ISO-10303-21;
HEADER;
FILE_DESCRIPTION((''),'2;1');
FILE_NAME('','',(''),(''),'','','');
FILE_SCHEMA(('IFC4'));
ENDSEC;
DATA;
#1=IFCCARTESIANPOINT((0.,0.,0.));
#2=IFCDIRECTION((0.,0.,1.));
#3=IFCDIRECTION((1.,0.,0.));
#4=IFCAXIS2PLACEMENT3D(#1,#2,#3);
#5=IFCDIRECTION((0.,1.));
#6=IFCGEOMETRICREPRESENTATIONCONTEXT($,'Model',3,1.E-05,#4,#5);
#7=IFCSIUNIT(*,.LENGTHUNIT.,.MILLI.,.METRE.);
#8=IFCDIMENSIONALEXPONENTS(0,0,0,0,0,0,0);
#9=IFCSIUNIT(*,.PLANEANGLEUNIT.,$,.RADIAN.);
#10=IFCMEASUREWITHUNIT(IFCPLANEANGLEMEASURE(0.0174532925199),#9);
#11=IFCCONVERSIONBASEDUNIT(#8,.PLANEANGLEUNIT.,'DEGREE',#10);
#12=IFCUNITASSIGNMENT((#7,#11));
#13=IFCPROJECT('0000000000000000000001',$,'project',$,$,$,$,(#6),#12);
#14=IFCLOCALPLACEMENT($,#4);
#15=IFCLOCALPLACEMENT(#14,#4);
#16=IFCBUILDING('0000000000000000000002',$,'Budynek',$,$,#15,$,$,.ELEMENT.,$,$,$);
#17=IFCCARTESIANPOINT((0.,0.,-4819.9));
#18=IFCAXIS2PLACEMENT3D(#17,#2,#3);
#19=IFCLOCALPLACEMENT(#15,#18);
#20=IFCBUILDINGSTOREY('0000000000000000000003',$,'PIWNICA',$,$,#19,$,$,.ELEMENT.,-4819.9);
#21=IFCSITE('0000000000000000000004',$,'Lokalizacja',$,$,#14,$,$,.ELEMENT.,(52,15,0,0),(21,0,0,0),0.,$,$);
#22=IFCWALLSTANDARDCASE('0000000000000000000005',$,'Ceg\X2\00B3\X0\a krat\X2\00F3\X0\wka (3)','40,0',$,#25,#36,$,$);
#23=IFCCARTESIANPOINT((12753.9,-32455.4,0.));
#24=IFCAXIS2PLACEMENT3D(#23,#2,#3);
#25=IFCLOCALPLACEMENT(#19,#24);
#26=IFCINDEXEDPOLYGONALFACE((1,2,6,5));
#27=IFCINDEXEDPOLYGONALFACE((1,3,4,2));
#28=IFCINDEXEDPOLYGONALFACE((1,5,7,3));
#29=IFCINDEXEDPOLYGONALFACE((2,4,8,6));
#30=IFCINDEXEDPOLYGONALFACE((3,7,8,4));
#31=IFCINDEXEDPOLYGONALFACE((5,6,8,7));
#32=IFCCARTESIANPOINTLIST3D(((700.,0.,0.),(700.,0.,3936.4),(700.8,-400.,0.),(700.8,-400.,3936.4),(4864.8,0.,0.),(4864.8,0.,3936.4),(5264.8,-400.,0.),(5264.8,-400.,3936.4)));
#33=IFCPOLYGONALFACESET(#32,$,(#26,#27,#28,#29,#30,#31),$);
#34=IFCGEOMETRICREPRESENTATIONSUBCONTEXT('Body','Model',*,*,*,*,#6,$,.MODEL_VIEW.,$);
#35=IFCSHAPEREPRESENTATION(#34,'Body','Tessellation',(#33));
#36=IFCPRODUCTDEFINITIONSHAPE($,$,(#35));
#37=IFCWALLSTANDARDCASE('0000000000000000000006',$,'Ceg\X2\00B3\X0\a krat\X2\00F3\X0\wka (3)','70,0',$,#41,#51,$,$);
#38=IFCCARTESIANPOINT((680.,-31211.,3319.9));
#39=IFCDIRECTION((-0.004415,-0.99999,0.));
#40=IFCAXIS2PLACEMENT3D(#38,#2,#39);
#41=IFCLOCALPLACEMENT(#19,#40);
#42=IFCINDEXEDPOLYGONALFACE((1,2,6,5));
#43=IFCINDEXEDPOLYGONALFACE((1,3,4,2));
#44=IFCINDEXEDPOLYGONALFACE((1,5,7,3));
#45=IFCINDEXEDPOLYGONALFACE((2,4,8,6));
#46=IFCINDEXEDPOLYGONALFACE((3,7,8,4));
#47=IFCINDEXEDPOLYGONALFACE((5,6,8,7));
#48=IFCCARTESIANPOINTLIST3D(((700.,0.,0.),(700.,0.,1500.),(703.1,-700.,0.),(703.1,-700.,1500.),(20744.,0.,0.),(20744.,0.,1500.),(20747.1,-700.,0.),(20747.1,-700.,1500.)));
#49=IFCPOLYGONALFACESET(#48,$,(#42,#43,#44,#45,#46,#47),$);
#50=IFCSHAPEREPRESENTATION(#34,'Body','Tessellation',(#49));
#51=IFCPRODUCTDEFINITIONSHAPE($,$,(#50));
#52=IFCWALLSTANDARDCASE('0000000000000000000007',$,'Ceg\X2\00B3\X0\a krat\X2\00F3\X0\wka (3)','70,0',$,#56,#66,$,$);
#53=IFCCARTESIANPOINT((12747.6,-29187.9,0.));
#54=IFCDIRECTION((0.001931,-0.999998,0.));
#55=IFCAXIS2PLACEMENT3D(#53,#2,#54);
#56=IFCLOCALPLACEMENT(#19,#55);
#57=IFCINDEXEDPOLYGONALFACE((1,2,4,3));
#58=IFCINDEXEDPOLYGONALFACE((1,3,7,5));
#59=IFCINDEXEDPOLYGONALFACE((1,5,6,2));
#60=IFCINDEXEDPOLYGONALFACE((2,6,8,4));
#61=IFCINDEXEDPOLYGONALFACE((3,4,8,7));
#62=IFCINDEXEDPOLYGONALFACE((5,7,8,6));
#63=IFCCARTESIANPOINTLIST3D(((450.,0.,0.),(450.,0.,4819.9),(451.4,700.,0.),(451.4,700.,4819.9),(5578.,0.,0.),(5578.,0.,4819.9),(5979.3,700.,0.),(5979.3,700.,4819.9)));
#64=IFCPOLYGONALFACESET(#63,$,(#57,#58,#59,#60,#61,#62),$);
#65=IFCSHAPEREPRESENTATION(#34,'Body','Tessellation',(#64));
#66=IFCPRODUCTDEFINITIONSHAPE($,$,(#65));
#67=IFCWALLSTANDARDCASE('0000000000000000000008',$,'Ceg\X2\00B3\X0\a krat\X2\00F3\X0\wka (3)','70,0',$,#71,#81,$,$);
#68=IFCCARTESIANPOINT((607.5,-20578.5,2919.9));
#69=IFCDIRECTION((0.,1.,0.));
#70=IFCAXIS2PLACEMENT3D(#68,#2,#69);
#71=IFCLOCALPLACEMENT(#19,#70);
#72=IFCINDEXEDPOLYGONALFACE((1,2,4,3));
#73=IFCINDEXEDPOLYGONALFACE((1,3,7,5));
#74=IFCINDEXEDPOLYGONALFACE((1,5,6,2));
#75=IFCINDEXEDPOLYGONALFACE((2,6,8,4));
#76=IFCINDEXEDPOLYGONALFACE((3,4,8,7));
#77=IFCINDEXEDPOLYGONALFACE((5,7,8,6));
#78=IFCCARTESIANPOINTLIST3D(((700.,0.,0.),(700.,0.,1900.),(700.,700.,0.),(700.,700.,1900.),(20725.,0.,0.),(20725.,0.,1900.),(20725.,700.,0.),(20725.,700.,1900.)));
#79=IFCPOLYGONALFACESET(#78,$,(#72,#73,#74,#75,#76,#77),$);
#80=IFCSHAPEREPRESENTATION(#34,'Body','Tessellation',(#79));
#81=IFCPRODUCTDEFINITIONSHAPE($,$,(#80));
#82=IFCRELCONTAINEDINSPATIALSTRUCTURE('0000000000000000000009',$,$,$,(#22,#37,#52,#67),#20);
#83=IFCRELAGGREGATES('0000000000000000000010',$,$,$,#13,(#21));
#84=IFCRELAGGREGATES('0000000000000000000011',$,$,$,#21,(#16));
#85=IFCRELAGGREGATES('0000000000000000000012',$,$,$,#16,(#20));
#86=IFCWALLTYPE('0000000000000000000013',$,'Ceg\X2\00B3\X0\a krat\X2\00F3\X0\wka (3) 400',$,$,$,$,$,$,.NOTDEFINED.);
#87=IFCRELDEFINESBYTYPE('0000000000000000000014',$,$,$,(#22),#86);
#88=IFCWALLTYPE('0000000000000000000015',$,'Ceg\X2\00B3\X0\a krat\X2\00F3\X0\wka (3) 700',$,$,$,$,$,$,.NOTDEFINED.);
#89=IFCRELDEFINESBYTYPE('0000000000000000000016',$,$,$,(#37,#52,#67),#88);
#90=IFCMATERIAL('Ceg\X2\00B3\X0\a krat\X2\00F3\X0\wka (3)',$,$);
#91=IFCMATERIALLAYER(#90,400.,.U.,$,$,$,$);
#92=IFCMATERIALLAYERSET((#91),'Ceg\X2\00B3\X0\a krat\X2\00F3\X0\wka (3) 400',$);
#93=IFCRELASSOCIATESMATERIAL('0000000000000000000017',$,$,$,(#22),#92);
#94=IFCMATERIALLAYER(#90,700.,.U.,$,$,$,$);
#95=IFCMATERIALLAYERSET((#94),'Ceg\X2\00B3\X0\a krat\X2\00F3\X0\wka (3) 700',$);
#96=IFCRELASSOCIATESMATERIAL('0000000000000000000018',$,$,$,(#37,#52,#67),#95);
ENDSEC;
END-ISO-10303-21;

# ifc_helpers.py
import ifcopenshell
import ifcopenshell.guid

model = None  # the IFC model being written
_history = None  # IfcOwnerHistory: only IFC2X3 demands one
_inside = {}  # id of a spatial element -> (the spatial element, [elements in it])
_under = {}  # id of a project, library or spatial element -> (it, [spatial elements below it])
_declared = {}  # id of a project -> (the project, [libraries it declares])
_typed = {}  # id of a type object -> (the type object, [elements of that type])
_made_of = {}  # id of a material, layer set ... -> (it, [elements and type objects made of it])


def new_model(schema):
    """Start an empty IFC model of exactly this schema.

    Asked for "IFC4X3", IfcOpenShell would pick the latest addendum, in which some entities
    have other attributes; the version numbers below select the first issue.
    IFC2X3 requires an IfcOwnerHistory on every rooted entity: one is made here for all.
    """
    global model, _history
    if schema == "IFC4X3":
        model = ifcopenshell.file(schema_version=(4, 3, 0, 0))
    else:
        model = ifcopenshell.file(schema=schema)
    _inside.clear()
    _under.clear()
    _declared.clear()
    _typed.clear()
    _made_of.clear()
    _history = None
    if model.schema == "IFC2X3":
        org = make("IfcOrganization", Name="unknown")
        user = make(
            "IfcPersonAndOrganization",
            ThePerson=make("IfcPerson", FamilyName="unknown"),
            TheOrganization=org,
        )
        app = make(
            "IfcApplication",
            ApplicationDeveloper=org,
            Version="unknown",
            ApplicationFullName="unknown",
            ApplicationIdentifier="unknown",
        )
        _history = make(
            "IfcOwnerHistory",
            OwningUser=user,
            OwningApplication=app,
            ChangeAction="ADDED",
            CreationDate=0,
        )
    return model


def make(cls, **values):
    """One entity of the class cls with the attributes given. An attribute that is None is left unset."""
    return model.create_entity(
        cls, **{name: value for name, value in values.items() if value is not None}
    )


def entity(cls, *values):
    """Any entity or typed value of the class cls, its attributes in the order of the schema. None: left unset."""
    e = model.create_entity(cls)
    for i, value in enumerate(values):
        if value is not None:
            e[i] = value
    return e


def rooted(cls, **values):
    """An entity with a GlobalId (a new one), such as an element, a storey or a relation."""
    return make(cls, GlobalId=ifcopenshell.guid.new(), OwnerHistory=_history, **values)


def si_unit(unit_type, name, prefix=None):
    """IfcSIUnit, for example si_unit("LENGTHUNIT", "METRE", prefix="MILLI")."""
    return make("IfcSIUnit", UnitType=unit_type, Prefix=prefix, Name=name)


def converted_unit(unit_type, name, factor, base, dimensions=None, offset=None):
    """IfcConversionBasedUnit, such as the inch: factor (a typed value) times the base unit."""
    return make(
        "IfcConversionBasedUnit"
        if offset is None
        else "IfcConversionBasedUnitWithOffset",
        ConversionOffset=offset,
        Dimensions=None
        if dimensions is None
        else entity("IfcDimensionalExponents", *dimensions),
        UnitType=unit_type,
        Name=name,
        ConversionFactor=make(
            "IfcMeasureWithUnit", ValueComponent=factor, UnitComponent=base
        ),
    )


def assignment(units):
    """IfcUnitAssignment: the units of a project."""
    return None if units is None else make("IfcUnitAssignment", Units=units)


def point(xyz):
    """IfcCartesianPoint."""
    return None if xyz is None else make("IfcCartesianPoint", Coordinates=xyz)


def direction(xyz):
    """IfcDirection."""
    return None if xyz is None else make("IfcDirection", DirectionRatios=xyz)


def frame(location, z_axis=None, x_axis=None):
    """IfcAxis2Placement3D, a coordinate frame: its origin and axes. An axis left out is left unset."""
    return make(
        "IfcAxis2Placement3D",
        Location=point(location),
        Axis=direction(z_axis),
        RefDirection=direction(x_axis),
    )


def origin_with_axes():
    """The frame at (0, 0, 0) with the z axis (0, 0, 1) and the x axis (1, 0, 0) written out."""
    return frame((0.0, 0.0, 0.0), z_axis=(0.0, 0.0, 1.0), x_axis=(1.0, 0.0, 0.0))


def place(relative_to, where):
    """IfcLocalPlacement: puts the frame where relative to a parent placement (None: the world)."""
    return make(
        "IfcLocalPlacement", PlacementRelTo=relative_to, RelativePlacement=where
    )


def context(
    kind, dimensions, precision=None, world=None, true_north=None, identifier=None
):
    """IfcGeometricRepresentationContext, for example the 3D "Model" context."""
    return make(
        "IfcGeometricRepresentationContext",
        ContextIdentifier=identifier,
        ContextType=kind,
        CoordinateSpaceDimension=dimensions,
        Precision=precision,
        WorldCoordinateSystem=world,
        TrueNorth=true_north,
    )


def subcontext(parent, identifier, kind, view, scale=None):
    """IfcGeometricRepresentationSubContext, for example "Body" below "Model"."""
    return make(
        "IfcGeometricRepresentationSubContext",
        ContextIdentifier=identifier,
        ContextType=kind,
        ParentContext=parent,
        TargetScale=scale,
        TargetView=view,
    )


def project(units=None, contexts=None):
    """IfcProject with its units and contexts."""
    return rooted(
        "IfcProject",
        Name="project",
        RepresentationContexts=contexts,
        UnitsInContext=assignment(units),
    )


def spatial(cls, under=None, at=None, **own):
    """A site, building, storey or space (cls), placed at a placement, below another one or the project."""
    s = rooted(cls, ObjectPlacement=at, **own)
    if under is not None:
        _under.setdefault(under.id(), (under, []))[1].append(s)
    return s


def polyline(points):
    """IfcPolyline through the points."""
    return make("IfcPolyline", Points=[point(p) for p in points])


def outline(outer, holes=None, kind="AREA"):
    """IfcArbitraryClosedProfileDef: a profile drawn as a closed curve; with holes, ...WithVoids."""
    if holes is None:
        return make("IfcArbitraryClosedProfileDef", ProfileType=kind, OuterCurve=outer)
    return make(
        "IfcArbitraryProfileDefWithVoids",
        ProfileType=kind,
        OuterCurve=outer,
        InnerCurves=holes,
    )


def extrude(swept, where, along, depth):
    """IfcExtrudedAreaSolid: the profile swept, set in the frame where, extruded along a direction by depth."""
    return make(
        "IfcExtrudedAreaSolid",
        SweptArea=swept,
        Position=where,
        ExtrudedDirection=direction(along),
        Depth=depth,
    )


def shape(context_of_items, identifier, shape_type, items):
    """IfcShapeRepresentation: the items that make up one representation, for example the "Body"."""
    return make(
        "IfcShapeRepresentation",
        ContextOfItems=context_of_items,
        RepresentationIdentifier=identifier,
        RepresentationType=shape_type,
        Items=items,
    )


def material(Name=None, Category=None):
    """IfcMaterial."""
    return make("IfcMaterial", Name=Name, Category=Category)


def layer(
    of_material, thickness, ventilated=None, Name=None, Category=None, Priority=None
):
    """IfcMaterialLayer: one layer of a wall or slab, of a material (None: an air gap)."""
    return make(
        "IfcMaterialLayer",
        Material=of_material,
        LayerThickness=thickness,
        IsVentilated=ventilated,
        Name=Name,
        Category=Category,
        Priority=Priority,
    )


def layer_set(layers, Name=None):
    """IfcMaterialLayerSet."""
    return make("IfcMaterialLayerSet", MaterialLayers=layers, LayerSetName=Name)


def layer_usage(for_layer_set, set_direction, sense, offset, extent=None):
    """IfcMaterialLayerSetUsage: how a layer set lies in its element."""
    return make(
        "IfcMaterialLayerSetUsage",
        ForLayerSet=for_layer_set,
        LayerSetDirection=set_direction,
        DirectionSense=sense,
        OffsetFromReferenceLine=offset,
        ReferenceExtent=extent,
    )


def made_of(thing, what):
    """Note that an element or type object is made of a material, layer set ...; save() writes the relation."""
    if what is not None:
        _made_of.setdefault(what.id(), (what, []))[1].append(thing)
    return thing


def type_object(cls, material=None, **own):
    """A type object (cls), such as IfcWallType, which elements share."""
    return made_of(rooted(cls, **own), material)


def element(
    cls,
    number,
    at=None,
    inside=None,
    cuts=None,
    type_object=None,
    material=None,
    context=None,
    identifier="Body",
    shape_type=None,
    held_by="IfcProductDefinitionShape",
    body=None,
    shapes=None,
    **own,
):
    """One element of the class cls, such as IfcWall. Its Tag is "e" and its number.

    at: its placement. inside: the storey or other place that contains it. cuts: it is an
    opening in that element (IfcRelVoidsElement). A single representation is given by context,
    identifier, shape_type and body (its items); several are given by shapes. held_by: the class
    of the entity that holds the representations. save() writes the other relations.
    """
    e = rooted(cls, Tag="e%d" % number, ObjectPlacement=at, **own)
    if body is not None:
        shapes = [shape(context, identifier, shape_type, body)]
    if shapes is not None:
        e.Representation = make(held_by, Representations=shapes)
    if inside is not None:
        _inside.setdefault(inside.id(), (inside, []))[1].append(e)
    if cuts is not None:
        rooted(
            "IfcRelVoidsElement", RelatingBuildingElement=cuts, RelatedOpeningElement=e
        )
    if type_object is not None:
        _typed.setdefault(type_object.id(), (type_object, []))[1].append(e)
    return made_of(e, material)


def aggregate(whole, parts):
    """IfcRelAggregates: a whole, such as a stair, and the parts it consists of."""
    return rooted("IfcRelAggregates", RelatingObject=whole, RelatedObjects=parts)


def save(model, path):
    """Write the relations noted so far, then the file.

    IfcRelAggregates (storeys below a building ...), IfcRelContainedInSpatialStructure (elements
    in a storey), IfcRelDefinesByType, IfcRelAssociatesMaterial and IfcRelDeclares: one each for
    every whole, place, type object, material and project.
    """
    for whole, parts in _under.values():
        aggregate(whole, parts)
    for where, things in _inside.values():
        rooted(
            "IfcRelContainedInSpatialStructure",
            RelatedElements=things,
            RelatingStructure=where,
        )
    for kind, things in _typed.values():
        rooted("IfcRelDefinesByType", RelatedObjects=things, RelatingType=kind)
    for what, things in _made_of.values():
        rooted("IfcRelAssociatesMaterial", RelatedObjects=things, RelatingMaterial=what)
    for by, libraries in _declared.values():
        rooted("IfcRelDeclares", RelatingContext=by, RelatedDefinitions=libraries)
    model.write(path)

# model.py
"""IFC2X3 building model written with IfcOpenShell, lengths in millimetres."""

from ifc_helpers import new_model, entity, si_unit, converted_unit, direction, frame, origin_with_axes, place, context, subcontext, project, spatial, polyline, outline, extrude, material, layer, layer_set, layer_usage, type_object, element, save


model = new_model("IFC2X3")

# Units and contexts
model_context = context("Model", 3, precision=1e-05, world=origin_with_axes(), true_north=direction((0.0, 1.0)))
body_context = subcontext(model_context, "Body", "Model", "MODEL_VIEW")
ifc_project = project(units=[si_unit("LENGTHUNIT", "METRE", prefix="MILLI"), converted_unit("PLANEANGLEUNIT", "DEGREE", entity("IfcPlaneAngleMeasure", 0.0174532925199), si_unit("PLANEANGLEUNIT", "RADIAN"), dimensions=[0, 0, 0, 0, 0, 0, 0])], contexts=[model_context])

# Site, building, storey
site_placement = place(None, origin_with_axes())
site = spatial("IfcSite", under=ifc_project, at=site_placement, Name="Lokalizacja", CompositionType="ELEMENT", RefLatitude=(52, 15, 0, 0), RefLongitude=(21, 0, 0, 0), RefElevation=0.0)
building_placement = place(site_placement, origin_with_axes())
building = spatial("IfcBuilding", under=site, at=building_placement, Name="Budynek", CompositionType="ELEMENT")
storey_placement = place(building_placement, frame((0.0, 0.0, -4819.9), z_axis=(0.0, 0.0, 1.0), x_axis=(1.0, 0.0, 0.0)))
storey = spatial("IfcBuildingStorey", under=building, at=storey_placement, Name="PIWNICA", CompositionType="ELEMENT", Elevation=-4819.9)

# Wall
ifc_material_1 = material(Name="Ceg³a kratówka (3)")
ifc_layer_1 = layer(ifc_material_1, 400.0, ventilated="UNKNOWN")
ifc_layer_set_1 = layer_set([ifc_layer_1], Name="Ceg³a kratówka (3) 400")
wall_type_1 = type_object("IfcWallType", Name="Ceg³a kratówka (3) 400", PredefinedType="NOTDEFINED")
ifc_layer_usage_1 = layer_usage(ifc_layer_set_1, "AXIS2", "NEGATIVE", 0.0)
wall_1_placement = place(storey_placement, frame((12753.9, -32455.4, 0.0), z_axis=(0.0, 0.0, 1.0), x_axis=(1.0, 0.0, 0.0)))
element("IfcWallStandardCase", 1, at=wall_1_placement, inside=storey, type_object=wall_type_1, material=ifc_layer_usage_1, Name="Ceg³a kratówka (3)", Description="40,0", context=body_context, shape_type="SweptSolid", body=[
    extrude(outline(polyline([(700.8, -400.0), (5264.8, -400.0), (4864.8, 0.0), (700.0, 0.0), (700.8, -400.0)])), origin_with_axes(), (0.0, 0.0, 1.0), 3936.4),
])

# Walls
ifc_layer_2 = layer(ifc_material_1, 700.0, ventilated="UNKNOWN")
ifc_layer_set_2 = layer_set([ifc_layer_2], Name="Ceg³a kratówka (3) 700")
wall_type_2 = type_object("IfcWallType", Name="Ceg³a kratówka (3) 700", PredefinedType="NOTDEFINED")
ifc_layer_usage_2 = layer_usage(ifc_layer_set_2, "AXIS2", "NEGATIVE", 0.0)
wall_2_placement = place(storey_placement, frame((680.0, -31211.0, 3319.9), z_axis=(0.0, 0.0, 1.0), x_axis=(-0.004415, -0.99999, 0.0)))
element("IfcWallStandardCase", 2, at=wall_2_placement, inside=storey, type_object=wall_type_2, material=ifc_layer_usage_2, Name="Ceg³a kratówka (3)", Description="70,0", context=body_context, shape_type="SweptSolid", body=[
    extrude(outline(polyline([(703.1, -700.0), (20747.1, -700.0), (20744.0, 0.0), (700.0, 0.0), (703.1, -700.0)])), origin_with_axes(), (0.0, 0.0, 1.0), 1500.0),
])
ifc_layer_usage_3 = layer_usage(ifc_layer_set_2, "AXIS2", "POSITIVE", 0.0)
wall_3_placement = place(storey_placement, frame((12747.6, -29187.9, 0.0), z_axis=(0.0, 0.0, 1.0), x_axis=(0.001931, -0.999998, 0.0)))
element("IfcWallStandardCase", 3, at=wall_3_placement, inside=storey, type_object=wall_type_2, material=ifc_layer_usage_3, Name="Ceg³a kratówka (3)", Description="70,0", context=body_context, shape_type="SweptSolid", body=[
    extrude(outline(polyline([(450.0, 0.0), (5578.0, 0.0), (5979.3, 700.0), (451.4, 700.0), (450.0, 0.0)])), origin_with_axes(), (0.0, 0.0, 1.0), 4819.9),
])
ifc_layer_usage_4 = layer_usage(ifc_layer_set_2, "AXIS2", "POSITIVE", 0.0)
wall_4_placement = place(storey_placement, frame((607.5, -20578.5, 2919.9), z_axis=(0.0, 0.0, 1.0), x_axis=(0.0, 1.0, 0.0)))
element("IfcWallStandardCase", 4, at=wall_4_placement, inside=storey, type_object=wall_type_2, material=ifc_layer_usage_4, Name="Ceg³a kratówka (3)", Description="70,0", context=body_context, shape_type="SweptSolid", body=[
    extrude(outline(polyline([(700.0, 0.0), (20725.0, 0.0), (20725.0, 700.0), (700.0, 700.0), (700.0, 0.0)])), origin_with_axes(), (0.0, 0.0, 1.0), 1900.0),
])

save(model, "model.ifc")
